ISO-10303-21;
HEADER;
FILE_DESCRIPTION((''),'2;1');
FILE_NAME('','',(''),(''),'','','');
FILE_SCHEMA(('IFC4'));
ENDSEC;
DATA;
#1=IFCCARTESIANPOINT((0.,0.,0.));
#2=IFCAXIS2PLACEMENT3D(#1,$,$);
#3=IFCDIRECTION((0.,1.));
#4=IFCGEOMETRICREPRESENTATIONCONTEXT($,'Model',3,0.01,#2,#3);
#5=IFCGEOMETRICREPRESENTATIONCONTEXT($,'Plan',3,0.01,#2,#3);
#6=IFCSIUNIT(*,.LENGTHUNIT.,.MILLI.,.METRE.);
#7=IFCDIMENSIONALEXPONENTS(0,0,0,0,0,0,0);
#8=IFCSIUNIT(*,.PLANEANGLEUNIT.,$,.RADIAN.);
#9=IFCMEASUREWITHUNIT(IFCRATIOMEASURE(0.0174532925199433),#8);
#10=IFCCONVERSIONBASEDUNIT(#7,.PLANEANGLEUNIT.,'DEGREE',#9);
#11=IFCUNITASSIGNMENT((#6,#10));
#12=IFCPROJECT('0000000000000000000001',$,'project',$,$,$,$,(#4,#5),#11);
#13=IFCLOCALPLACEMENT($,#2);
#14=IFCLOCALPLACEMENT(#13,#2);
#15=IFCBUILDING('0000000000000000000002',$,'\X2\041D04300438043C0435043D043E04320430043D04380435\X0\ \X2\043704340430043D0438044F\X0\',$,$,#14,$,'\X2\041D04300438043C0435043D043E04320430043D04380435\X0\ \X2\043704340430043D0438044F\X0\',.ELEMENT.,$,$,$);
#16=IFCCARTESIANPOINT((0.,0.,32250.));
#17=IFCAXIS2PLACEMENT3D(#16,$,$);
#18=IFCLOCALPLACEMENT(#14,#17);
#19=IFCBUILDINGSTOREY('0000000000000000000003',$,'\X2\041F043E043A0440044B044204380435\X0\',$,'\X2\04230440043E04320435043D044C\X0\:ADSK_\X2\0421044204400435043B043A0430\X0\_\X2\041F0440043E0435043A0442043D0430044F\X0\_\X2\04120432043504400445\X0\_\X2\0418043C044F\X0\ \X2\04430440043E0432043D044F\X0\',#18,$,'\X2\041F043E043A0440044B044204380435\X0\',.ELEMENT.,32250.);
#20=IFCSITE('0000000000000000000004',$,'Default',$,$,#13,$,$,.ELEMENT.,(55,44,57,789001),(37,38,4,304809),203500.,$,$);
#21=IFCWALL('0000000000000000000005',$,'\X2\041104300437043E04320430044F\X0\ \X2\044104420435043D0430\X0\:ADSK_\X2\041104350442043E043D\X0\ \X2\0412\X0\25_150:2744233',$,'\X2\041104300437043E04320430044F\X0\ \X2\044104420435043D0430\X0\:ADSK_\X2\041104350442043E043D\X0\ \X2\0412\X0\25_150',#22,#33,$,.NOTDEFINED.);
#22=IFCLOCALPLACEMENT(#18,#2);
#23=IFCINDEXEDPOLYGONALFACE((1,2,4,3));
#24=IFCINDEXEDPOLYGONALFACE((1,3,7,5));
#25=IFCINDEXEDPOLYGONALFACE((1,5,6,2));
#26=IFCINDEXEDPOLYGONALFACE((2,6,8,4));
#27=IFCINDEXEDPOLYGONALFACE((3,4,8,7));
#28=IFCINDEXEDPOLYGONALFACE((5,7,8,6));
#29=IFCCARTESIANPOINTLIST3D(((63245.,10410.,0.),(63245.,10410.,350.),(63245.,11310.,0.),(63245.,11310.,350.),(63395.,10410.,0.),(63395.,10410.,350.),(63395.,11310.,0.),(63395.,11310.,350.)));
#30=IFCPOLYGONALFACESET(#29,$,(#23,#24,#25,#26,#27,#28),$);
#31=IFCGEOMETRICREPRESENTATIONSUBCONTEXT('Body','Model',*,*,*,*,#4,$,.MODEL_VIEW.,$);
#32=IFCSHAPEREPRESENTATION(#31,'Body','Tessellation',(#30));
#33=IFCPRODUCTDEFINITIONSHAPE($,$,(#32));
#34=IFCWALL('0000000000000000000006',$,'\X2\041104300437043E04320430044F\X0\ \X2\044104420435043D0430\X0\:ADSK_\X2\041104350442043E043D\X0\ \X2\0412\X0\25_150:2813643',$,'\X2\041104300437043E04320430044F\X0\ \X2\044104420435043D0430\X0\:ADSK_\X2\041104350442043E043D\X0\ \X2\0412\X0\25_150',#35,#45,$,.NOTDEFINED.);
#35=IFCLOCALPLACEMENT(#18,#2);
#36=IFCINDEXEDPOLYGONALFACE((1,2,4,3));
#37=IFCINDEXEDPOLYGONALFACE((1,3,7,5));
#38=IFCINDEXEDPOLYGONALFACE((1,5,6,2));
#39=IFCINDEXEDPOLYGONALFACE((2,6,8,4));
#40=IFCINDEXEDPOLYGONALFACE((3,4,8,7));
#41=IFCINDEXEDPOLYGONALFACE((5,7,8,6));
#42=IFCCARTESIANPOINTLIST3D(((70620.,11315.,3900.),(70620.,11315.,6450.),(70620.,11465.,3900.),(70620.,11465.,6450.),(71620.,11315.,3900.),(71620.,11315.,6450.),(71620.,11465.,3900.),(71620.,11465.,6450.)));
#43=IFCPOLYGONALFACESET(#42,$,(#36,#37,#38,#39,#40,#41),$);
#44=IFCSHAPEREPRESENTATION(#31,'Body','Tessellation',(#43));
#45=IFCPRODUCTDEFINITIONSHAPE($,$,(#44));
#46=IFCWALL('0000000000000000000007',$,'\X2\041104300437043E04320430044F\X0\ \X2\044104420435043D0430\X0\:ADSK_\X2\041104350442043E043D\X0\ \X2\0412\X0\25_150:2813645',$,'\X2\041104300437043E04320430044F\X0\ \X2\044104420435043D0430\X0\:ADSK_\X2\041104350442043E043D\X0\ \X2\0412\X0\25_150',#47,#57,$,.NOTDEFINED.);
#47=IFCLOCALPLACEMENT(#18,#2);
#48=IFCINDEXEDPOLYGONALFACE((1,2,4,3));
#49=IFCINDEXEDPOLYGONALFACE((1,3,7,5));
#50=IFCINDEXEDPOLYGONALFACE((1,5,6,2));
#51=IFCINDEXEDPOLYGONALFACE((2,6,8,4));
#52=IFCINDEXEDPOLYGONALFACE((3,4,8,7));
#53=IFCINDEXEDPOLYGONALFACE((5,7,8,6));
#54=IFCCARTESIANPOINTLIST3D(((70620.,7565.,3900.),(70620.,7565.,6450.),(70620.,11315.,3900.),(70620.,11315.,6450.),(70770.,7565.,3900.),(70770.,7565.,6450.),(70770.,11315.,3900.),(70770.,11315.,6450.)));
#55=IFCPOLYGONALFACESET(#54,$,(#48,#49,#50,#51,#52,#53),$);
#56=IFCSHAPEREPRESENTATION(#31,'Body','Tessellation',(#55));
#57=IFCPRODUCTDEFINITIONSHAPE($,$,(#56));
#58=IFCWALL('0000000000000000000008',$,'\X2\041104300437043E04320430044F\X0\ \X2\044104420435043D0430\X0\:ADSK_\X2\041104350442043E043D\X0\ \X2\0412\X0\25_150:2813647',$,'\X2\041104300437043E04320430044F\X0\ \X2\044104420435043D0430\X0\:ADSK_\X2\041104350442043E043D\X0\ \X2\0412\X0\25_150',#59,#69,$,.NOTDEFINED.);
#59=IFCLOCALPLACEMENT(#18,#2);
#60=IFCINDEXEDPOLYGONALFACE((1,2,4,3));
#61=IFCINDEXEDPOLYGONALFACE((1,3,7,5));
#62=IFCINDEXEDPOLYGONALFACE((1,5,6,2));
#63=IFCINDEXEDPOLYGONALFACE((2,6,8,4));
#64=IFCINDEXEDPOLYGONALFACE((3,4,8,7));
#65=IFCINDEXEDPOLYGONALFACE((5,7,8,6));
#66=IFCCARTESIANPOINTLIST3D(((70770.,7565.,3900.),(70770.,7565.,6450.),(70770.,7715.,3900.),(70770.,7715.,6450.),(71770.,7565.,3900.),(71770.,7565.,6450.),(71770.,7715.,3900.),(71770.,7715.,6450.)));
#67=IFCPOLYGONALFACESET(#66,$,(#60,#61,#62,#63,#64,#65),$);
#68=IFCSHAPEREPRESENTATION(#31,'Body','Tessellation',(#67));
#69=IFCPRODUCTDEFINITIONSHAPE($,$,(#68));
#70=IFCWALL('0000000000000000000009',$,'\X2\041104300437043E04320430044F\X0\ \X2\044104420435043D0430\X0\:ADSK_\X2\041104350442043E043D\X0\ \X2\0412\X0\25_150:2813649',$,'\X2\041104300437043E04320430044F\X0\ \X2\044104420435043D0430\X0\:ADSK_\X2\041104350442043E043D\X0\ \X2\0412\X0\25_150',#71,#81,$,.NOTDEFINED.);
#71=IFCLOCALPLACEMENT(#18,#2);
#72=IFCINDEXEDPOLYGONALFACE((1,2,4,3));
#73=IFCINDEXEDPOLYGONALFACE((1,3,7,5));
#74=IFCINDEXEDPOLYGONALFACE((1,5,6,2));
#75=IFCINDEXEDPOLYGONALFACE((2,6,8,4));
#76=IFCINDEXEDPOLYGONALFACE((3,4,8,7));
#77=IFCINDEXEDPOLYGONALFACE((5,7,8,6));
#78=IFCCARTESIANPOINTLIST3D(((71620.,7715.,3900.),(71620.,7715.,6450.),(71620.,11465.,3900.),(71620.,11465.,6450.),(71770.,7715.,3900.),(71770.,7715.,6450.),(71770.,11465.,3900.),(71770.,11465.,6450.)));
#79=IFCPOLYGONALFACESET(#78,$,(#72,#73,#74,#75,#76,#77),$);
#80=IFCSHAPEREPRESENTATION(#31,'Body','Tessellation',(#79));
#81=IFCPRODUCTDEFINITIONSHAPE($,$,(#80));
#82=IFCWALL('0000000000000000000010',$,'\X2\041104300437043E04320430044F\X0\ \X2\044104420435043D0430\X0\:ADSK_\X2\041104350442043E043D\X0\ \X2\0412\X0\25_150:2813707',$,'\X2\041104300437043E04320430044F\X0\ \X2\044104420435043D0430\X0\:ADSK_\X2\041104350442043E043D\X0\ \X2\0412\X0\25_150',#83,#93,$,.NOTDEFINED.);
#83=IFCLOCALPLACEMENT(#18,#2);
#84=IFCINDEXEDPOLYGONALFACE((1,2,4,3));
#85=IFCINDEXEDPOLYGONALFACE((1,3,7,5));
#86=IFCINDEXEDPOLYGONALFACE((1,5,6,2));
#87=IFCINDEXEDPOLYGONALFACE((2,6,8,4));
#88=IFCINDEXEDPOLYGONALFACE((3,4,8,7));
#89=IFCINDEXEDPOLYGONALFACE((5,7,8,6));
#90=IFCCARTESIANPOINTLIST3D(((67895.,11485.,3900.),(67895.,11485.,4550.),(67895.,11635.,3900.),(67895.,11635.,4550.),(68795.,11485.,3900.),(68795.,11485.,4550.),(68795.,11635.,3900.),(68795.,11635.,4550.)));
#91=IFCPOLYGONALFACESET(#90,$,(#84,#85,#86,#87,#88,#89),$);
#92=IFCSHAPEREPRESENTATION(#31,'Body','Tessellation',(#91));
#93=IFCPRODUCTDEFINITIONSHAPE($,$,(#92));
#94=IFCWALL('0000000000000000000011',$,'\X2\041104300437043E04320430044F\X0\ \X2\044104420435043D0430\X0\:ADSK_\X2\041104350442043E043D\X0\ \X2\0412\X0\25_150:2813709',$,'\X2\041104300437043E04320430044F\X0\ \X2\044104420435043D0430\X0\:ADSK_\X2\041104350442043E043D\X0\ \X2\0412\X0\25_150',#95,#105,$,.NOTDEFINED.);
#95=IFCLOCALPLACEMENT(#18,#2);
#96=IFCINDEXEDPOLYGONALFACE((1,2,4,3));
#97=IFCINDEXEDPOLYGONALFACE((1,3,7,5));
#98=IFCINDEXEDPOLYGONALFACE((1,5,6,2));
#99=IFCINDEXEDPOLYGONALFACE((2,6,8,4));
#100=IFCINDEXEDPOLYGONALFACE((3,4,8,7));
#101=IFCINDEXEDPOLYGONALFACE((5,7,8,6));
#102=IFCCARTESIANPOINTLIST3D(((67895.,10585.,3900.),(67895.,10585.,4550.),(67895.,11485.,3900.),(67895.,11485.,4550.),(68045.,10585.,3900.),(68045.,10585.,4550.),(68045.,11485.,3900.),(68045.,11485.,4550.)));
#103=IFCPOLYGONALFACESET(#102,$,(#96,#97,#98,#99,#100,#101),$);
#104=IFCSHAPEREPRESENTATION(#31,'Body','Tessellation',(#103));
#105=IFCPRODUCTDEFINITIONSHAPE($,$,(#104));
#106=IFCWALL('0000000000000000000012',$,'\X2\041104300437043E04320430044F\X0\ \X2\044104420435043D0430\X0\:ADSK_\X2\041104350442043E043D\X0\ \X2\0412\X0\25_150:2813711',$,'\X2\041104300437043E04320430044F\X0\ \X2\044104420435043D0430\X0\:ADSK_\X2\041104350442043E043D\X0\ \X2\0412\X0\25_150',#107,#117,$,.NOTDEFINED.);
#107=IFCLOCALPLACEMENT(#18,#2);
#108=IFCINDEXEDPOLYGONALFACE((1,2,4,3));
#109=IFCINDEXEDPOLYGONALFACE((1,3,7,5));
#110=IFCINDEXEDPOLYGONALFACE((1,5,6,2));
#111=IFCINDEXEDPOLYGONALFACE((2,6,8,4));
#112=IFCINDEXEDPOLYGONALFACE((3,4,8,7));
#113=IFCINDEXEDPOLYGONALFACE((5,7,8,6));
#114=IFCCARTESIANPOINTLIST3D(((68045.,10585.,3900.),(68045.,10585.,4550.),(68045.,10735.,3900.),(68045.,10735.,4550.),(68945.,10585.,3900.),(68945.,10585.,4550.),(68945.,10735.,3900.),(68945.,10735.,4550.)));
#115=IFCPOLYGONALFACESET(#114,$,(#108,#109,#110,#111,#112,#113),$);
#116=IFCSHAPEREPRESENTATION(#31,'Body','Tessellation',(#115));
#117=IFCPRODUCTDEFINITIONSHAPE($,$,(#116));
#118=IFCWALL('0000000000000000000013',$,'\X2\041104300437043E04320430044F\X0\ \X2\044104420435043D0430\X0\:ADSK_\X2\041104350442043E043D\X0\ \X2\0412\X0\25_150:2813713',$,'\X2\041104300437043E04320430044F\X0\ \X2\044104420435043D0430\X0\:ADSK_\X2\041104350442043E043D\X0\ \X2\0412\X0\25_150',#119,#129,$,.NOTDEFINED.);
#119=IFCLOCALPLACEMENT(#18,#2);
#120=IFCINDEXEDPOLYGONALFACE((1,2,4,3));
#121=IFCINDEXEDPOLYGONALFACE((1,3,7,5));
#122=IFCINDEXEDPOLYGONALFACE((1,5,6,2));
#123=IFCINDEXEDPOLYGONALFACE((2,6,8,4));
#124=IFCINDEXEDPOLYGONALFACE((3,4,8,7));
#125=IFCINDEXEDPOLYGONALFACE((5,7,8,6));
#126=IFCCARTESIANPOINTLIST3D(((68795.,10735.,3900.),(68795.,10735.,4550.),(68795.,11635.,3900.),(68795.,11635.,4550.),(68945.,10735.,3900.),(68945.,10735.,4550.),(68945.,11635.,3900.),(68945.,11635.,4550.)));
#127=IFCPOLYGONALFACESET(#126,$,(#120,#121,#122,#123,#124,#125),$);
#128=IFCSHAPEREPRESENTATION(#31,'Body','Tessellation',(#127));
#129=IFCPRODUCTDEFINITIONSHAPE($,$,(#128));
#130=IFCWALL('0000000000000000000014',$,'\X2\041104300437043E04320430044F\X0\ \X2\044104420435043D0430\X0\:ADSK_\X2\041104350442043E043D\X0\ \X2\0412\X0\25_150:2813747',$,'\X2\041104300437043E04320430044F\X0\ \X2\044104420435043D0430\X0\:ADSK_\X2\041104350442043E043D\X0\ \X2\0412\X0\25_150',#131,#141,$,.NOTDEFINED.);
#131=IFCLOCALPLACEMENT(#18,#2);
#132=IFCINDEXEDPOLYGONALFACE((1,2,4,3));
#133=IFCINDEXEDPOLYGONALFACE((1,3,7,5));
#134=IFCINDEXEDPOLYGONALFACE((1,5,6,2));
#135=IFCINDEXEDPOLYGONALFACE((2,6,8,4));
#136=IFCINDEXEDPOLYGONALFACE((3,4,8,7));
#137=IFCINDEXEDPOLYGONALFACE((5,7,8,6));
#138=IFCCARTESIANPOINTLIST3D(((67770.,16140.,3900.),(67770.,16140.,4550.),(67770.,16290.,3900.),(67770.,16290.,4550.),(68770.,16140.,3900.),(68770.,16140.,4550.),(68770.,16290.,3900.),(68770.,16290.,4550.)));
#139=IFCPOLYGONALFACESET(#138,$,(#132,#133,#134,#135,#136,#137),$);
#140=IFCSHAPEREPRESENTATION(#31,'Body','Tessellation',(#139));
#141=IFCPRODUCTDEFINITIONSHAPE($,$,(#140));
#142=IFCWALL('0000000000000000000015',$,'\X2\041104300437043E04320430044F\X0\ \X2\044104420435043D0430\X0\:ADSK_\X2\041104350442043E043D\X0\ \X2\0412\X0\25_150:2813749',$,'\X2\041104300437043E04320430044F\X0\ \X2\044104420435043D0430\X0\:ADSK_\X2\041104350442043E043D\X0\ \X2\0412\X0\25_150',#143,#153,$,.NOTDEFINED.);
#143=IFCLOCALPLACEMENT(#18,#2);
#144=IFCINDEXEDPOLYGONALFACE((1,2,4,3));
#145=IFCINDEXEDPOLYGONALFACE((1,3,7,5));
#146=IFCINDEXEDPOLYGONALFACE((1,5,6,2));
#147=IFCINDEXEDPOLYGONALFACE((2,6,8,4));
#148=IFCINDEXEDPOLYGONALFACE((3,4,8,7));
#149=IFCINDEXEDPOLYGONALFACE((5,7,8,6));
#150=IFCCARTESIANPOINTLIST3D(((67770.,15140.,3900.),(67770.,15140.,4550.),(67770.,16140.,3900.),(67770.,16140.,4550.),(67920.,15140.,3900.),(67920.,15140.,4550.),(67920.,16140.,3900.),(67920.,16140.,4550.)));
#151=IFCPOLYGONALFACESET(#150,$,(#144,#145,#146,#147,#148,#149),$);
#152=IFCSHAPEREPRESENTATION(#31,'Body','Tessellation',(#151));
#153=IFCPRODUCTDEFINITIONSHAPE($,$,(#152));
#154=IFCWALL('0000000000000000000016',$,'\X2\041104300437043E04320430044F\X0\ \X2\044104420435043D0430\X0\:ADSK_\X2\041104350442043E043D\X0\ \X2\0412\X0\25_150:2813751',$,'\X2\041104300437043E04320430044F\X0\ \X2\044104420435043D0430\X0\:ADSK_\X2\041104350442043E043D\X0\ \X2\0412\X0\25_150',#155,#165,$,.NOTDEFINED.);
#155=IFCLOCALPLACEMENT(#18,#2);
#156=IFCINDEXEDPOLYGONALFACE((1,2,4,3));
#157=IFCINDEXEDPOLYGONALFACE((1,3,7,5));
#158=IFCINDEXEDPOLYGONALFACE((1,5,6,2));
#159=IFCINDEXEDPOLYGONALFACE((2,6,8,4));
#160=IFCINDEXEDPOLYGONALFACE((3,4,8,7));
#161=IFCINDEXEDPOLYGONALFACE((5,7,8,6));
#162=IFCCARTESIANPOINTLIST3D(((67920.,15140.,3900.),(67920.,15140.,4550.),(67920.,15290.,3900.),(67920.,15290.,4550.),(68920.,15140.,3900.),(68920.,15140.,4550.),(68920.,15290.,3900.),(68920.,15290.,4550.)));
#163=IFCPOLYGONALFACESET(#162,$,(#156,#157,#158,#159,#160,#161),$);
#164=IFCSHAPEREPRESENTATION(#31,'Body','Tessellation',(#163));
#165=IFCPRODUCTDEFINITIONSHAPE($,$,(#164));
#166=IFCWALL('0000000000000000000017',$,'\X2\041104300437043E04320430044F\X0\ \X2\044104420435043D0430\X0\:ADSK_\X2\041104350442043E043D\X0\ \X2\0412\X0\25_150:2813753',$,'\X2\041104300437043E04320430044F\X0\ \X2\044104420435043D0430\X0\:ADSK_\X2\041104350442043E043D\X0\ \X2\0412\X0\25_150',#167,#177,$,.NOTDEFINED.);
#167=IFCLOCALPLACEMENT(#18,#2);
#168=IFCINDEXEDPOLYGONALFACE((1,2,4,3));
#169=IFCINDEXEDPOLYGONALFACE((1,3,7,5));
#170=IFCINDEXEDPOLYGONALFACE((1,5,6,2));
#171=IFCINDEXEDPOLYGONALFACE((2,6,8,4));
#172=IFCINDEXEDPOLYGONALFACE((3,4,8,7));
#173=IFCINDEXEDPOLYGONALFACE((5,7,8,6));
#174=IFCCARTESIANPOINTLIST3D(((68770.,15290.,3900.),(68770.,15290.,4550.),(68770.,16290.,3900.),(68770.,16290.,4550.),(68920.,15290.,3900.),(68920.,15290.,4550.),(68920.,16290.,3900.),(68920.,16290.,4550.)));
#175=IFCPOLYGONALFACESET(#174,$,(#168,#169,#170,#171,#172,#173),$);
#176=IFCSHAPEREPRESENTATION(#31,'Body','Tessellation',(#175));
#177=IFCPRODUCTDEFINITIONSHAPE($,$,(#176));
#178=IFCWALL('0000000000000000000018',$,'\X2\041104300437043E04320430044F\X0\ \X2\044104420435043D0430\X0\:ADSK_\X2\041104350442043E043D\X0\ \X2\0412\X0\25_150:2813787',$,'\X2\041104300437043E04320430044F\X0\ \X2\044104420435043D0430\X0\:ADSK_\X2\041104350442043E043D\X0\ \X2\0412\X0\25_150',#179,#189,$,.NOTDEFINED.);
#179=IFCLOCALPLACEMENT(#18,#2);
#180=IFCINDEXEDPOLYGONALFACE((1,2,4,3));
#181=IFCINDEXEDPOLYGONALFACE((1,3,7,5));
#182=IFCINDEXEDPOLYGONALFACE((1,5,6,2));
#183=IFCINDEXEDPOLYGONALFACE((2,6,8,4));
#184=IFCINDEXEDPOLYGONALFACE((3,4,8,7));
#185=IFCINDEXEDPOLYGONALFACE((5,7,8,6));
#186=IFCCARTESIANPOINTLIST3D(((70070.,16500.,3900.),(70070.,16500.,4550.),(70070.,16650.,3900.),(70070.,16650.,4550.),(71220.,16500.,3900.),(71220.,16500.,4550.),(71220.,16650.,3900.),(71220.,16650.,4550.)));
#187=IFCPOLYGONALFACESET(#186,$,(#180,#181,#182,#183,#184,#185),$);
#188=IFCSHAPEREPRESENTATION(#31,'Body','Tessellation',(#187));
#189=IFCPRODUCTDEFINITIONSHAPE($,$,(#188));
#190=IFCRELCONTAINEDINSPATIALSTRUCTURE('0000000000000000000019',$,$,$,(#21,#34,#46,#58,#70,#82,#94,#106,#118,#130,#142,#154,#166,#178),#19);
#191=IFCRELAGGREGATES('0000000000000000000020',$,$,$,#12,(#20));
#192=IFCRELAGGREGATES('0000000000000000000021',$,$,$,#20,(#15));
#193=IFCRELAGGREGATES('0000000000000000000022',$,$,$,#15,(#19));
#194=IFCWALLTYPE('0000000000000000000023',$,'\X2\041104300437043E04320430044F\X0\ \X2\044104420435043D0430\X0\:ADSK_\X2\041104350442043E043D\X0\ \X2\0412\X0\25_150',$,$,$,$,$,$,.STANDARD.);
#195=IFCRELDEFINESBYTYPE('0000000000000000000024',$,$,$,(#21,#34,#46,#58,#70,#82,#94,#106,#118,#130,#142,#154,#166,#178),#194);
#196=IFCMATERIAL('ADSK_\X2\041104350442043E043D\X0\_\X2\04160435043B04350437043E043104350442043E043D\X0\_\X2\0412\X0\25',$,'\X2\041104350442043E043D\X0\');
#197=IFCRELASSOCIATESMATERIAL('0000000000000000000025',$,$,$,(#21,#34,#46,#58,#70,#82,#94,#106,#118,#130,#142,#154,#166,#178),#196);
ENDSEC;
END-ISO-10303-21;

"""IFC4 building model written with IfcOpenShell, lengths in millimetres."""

from ifc_helpers import new_model, entity, si_unit, converted_unit, direction, frame, origin, place, context, subcontext, project, spatial, indexed_curve, outline, extrude, material, type_object, element, save


model = new_model("IFC4")

# Units and contexts
model_context = context("Model", 3, precision=0.01, world=origin(), true_north=direction((0.0, 1.0)))
plan_context = context("Plan", 3, precision=0.01, world=origin(), true_north=direction((0.0, 1.0)))
body_context = subcontext(model_context, "Body", "Model", "MODEL_VIEW")
ifc_project = project(units=[si_unit("LENGTHUNIT", "METRE", prefix="MILLI"), converted_unit("PLANEANGLEUNIT", "DEGREE", entity("IfcRatioMeasure", 0.0174532925199433), si_unit("PLANEANGLEUNIT", "RADIAN"), dimensions=[0, 0, 0, 0, 0, 0, 0])], contexts=[model_context, plan_context])

# Site, building, storey
site_placement = place(None, origin())
site = spatial("IfcSite", under=ifc_project, at=site_placement, Name="Default", CompositionType="ELEMENT", RefLatitude=(55, 44, 57, 789001), RefLongitude=(37, 38, 4, 304809), RefElevation=203500.0)
building_placement = place(site_placement, origin())
building = spatial("IfcBuilding", under=site, at=building_placement, Name="Наименование здания", LongName="Наименование здания", CompositionType="ELEMENT")
storey_placement = place(building_placement, frame((0.0, 0.0, 32250.0)))
storey = spatial("IfcBuildingStorey", under=building, at=storey_placement, Name="Покрытие", ObjectType="Уровень:ADSK_Стрелка_Проектная_Вверх_Имя уровня", LongName="Покрытие", CompositionType="ELEMENT", Elevation=32250.0)

# Walls
ifc_material = material(Name="ADSK_Бетон_Железобетон_В25", Category="Бетон")
wall_type_1 = type_object("IfcWallType", Name="Базовая стена:ADSK_Бетон В25_150", PredefinedType="STANDARD")
wall_1_placement = place(storey_placement, frame((63320.0, 11310.0, 0.0), z_axis=(0.0, 0.0, 1.0), x_axis=(0.0, -1.0, 0.0)))
element("IfcWall", 1, at=wall_1_placement, inside=storey, type_object=wall_type_1, material=ifc_material, Name="Базовая стена:ADSK_Бетон В25_150:2744233", ObjectType="Базовая стена:ADSK_Бетон В25_150", PredefinedType="NOTDEFINED", context=body_context, shape_type="SweptSolid", body=[
    extrude(outline(indexed_curve([(900.0, 75.0), (0.0, 75.0), (0.0, -75.0), (900.0, -75.0), (900.0, 75.0)], self_intersect=False)), origin(), (0.0, 0.0, 1.0), 350.0),
])
wall_2_placement = place(storey_placement, frame((70620.0, 11390.0, 3900.0)))
element("IfcWall", 2, at=wall_2_placement, inside=storey, type_object=wall_type_1, material=ifc_material, Name="Базовая стена:ADSK_Бетон В25_150:2813643", ObjectType="Базовая стена:ADSK_Бетон В25_150", PredefinedType="NOTDEFINED", context=body_context, shape_type="SweptSolid", body=[
    extrude(outline(indexed_curve([(1000.0, 75.0), (0.0, 75.0), (0.0, -75.0), (1000.0, -75.0), (1000.0, 75.0)], self_intersect=False)), origin(), (0.0, 0.0, 1.0), 2550.0),
])
wall_3_placement = place(storey_placement, frame((70695.0, 7565.0, 3900.0), z_axis=(0.0, 0.0, 1.0), x_axis=(0.0, 1.0, 0.0)))
element("IfcWall", 3, at=wall_3_placement, inside=storey, type_object=wall_type_1, material=ifc_material, Name="Базовая стена:ADSK_Бетон В25_150:2813645", ObjectType="Базовая стена:ADSK_Бетон В25_150", PredefinedType="NOTDEFINED", context=body_context, shape_type="SweptSolid", body=[
    extrude(outline(indexed_curve([(3750.0, 75.0), (0.0, 75.0), (0.0, -75.0), (3750.0, -75.0), (3750.0, 75.0)], self_intersect=False)), origin(), (0.0, 0.0, 1.0), 2550.0),
])
wall_4_placement = place(storey_placement, frame((71770.0, 7640.0, 3900.0), z_axis=(0.0, 0.0, 1.0), x_axis=(-1.0, 0.0, 0.0)))
element("IfcWall", 4, at=wall_4_placement, inside=storey, type_object=wall_type_1, material=ifc_material, Name="Базовая стена:ADSK_Бетон В25_150:2813647", ObjectType="Базовая стена:ADSK_Бетон В25_150", PredefinedType="NOTDEFINED", context=body_context, shape_type="SweptSolid", body=[
    extrude(outline(indexed_curve([(1000.0, 75.0), (0.0, 75.0), (0.0, -75.0), (1000.0, -75.0), (1000.0, 75.0)], self_intersect=False)), origin(), (0.0, 0.0, 1.0), 2550.0),
])
wall_5_placement = place(storey_placement, frame((71695.0, 11465.0, 3900.0), z_axis=(0.0, 0.0, 1.0), x_axis=(0.0, -1.0, 0.0)))
element("IfcWall", 5, at=wall_5_placement, inside=storey, type_object=wall_type_1, material=ifc_material, Name="Базовая стена:ADSK_Бетон В25_150:2813649", ObjectType="Базовая стена:ADSK_Бетон В25_150", PredefinedType="NOTDEFINED", context=body_context, shape_type="SweptSolid", body=[
    extrude(outline(indexed_curve([(3750.0, 75.0), (0.0, 75.0), (0.0, -75.0), (3750.0, -75.0), (3750.0, 75.0)], self_intersect=False)), origin(), (0.0, 0.0, 1.0), 2550.0),
])
wall_6_placement = place(storey_placement, frame((67895.0, 11560.0, 3900.0)))
element("IfcWall", 6, at=wall_6_placement, inside=storey, type_object=wall_type_1, material=ifc_material, Name="Базовая стена:ADSK_Бетон В25_150:2813707", ObjectType="Базовая стена:ADSK_Бетон В25_150", PredefinedType="NOTDEFINED", context=body_context, shape_type="SweptSolid", body=[
    extrude(outline(indexed_curve([(900.0, 75.0), (0.0, 75.0), (0.0, -75.0), (900.0, -75.0), (900.0, 75.0)], self_intersect=False)), origin(), (0.0, 0.0, 1.0), 650.0),
])
wall_7_placement = place(storey_placement, frame((67970.0, 10585.0, 3900.0), z_axis=(0.0, 0.0, 1.0), x_axis=(0.0, 1.0, 0.0)))
element("IfcWall", 7, at=wall_7_placement, inside=storey, type_object=wall_type_1, material=ifc_material, Name="Базовая стена:ADSK_Бетон В25_150:2813709", ObjectType="Базовая стена:ADSK_Бетон В25_150", PredefinedType="NOTDEFINED", context=body_context, shape_type="SweptSolid", body=[
    extrude(outline(indexed_curve([(900.0, 75.0), (0.0, 75.0), (0.0, -75.0), (900.0, -75.0), (900.0, 75.0)], self_intersect=False)), origin(), (0.0, 0.0, 1.0), 650.0),
])
wall_8_placement = place(storey_placement, frame((68945.0, 10660.0, 3900.0), z_axis=(0.0, 0.0, 1.0), x_axis=(-1.0, 0.0, 0.0)))
element("IfcWall", 8, at=wall_8_placement, inside=storey, type_object=wall_type_1, material=ifc_material, Name="Базовая стена:ADSK_Бетон В25_150:2813711", ObjectType="Базовая стена:ADSK_Бетон В25_150", PredefinedType="NOTDEFINED", context=body_context, shape_type="SweptSolid", body=[
    extrude(outline(indexed_curve([(900.0, 75.0), (0.0, 75.0), (0.0, -75.0), (900.0, -75.0), (900.0, 75.0)], self_intersect=False)), origin(), (0.0, 0.0, 1.0), 650.0),
])
wall_9_placement = place(storey_placement, frame((68870.0, 11635.0, 3900.0), z_axis=(0.0, 0.0, 1.0), x_axis=(0.0, -1.0, 0.0)))
element("IfcWall", 9, at=wall_9_placement, inside=storey, type_object=wall_type_1, material=ifc_material, Name="Базовая стена:ADSK_Бетон В25_150:2813713", ObjectType="Базовая стена:ADSK_Бетон В25_150", PredefinedType="NOTDEFINED", context=body_context, shape_type="SweptSolid", body=[
    extrude(outline(indexed_curve([(900.0, 75.0), (0.0, 75.0), (0.0, -75.0), (900.0, -75.0), (900.0, 75.0)], self_intersect=False)), origin(), (0.0, 0.0, 1.0), 650.0),
])
wall_10_placement = place(storey_placement, frame((67770.0, 16215.0, 3900.0)))
element("IfcWall", 10, at=wall_10_placement, inside=storey, type_object=wall_type_1, material=ifc_material, Name="Базовая стена:ADSK_Бетон В25_150:2813747", ObjectType="Базовая стена:ADSK_Бетон В25_150", PredefinedType="NOTDEFINED", context=body_context, shape_type="SweptSolid", body=[
    extrude(outline(indexed_curve([(1000.0, 75.0), (0.0, 75.0), (0.0, -75.0), (1000.0, -75.0), (1000.0, 75.0)], self_intersect=False)), origin(), (0.0, 0.0, 1.0), 650.0),
])
wall_11_placement = place(storey_placement, frame((67845.0, 15140.0, 3900.0), z_axis=(0.0, 0.0, 1.0), x_axis=(0.0, 1.0, 0.0)))
element("IfcWall", 11, at=wall_11_placement, inside=storey, type_object=wall_type_1, material=ifc_material, Name="Базовая стена:ADSK_Бетон В25_150:2813749", ObjectType="Базовая стена:ADSK_Бетон В25_150", PredefinedType="NOTDEFINED", context=body_context, shape_type="SweptSolid", body=[
    extrude(outline(indexed_curve([(1000.0, 75.0), (0.0, 75.0), (0.0, -75.0), (1000.0, -75.0), (1000.0, 75.0)], self_intersect=False)), origin(), (0.0, 0.0, 1.0), 650.0),
])
wall_12_placement = place(storey_placement, frame((68920.0, 15215.0, 3900.0), z_axis=(0.0, 0.0, 1.0), x_axis=(-1.0, 0.0, 0.0)))
element("IfcWall", 12, at=wall_12_placement, inside=storey, type_object=wall_type_1, material=ifc_material, Name="Базовая стена:ADSK_Бетон В25_150:2813751", ObjectType="Базовая стена:ADSK_Бетон В25_150", PredefinedType="NOTDEFINED", context=body_context, shape_type="SweptSolid", body=[
    extrude(outline(indexed_curve([(1000.0, 75.0), (0.0, 75.0), (0.0, -75.0), (1000.0, -75.0), (1000.0, 75.0)], self_intersect=False)), origin(), (0.0, 0.0, 1.0), 650.0),
])
wall_13_placement = place(storey_placement, frame((68845.0, 16290.0, 3900.0), z_axis=(0.0, 0.0, 1.0), x_axis=(0.0, -1.0, 0.0)))
element("IfcWall", 13, at=wall_13_placement, inside=storey, type_object=wall_type_1, material=ifc_material, Name="Базовая стена:ADSK_Бетон В25_150:2813753", ObjectType="Базовая стена:ADSK_Бетон В25_150", PredefinedType="NOTDEFINED", context=body_context, shape_type="SweptSolid", body=[
    extrude(outline(indexed_curve([(1000.0, 75.0), (0.0, 75.0), (0.0, -75.0), (1000.0, -75.0), (1000.0, 75.0)], self_intersect=False)), origin(), (0.0, 0.0, 1.0), 650.0),
])
wall_14_placement = place(storey_placement, frame((70070.0, 16575.0, 3900.0)))
element("IfcWall", 14, at=wall_14_placement, inside=storey, type_object=wall_type_1, material=ifc_material, Name="Базовая стена:ADSK_Бетон В25_150:2813787", ObjectType="Базовая стена:ADSK_Бетон В25_150", PredefinedType="NOTDEFINED", context=body_context, shape_type="SweptSolid", body=[
    extrude(outline(indexed_curve([(1150.0, 75.0), (0.0, 75.0), (0.0, -75.0), (1150.0, -75.0), (1150.0, 75.0)], self_intersect=False)), origin(), (0.0, 0.0, 1.0), 650.0),
])

save(model, "model.ifc")
